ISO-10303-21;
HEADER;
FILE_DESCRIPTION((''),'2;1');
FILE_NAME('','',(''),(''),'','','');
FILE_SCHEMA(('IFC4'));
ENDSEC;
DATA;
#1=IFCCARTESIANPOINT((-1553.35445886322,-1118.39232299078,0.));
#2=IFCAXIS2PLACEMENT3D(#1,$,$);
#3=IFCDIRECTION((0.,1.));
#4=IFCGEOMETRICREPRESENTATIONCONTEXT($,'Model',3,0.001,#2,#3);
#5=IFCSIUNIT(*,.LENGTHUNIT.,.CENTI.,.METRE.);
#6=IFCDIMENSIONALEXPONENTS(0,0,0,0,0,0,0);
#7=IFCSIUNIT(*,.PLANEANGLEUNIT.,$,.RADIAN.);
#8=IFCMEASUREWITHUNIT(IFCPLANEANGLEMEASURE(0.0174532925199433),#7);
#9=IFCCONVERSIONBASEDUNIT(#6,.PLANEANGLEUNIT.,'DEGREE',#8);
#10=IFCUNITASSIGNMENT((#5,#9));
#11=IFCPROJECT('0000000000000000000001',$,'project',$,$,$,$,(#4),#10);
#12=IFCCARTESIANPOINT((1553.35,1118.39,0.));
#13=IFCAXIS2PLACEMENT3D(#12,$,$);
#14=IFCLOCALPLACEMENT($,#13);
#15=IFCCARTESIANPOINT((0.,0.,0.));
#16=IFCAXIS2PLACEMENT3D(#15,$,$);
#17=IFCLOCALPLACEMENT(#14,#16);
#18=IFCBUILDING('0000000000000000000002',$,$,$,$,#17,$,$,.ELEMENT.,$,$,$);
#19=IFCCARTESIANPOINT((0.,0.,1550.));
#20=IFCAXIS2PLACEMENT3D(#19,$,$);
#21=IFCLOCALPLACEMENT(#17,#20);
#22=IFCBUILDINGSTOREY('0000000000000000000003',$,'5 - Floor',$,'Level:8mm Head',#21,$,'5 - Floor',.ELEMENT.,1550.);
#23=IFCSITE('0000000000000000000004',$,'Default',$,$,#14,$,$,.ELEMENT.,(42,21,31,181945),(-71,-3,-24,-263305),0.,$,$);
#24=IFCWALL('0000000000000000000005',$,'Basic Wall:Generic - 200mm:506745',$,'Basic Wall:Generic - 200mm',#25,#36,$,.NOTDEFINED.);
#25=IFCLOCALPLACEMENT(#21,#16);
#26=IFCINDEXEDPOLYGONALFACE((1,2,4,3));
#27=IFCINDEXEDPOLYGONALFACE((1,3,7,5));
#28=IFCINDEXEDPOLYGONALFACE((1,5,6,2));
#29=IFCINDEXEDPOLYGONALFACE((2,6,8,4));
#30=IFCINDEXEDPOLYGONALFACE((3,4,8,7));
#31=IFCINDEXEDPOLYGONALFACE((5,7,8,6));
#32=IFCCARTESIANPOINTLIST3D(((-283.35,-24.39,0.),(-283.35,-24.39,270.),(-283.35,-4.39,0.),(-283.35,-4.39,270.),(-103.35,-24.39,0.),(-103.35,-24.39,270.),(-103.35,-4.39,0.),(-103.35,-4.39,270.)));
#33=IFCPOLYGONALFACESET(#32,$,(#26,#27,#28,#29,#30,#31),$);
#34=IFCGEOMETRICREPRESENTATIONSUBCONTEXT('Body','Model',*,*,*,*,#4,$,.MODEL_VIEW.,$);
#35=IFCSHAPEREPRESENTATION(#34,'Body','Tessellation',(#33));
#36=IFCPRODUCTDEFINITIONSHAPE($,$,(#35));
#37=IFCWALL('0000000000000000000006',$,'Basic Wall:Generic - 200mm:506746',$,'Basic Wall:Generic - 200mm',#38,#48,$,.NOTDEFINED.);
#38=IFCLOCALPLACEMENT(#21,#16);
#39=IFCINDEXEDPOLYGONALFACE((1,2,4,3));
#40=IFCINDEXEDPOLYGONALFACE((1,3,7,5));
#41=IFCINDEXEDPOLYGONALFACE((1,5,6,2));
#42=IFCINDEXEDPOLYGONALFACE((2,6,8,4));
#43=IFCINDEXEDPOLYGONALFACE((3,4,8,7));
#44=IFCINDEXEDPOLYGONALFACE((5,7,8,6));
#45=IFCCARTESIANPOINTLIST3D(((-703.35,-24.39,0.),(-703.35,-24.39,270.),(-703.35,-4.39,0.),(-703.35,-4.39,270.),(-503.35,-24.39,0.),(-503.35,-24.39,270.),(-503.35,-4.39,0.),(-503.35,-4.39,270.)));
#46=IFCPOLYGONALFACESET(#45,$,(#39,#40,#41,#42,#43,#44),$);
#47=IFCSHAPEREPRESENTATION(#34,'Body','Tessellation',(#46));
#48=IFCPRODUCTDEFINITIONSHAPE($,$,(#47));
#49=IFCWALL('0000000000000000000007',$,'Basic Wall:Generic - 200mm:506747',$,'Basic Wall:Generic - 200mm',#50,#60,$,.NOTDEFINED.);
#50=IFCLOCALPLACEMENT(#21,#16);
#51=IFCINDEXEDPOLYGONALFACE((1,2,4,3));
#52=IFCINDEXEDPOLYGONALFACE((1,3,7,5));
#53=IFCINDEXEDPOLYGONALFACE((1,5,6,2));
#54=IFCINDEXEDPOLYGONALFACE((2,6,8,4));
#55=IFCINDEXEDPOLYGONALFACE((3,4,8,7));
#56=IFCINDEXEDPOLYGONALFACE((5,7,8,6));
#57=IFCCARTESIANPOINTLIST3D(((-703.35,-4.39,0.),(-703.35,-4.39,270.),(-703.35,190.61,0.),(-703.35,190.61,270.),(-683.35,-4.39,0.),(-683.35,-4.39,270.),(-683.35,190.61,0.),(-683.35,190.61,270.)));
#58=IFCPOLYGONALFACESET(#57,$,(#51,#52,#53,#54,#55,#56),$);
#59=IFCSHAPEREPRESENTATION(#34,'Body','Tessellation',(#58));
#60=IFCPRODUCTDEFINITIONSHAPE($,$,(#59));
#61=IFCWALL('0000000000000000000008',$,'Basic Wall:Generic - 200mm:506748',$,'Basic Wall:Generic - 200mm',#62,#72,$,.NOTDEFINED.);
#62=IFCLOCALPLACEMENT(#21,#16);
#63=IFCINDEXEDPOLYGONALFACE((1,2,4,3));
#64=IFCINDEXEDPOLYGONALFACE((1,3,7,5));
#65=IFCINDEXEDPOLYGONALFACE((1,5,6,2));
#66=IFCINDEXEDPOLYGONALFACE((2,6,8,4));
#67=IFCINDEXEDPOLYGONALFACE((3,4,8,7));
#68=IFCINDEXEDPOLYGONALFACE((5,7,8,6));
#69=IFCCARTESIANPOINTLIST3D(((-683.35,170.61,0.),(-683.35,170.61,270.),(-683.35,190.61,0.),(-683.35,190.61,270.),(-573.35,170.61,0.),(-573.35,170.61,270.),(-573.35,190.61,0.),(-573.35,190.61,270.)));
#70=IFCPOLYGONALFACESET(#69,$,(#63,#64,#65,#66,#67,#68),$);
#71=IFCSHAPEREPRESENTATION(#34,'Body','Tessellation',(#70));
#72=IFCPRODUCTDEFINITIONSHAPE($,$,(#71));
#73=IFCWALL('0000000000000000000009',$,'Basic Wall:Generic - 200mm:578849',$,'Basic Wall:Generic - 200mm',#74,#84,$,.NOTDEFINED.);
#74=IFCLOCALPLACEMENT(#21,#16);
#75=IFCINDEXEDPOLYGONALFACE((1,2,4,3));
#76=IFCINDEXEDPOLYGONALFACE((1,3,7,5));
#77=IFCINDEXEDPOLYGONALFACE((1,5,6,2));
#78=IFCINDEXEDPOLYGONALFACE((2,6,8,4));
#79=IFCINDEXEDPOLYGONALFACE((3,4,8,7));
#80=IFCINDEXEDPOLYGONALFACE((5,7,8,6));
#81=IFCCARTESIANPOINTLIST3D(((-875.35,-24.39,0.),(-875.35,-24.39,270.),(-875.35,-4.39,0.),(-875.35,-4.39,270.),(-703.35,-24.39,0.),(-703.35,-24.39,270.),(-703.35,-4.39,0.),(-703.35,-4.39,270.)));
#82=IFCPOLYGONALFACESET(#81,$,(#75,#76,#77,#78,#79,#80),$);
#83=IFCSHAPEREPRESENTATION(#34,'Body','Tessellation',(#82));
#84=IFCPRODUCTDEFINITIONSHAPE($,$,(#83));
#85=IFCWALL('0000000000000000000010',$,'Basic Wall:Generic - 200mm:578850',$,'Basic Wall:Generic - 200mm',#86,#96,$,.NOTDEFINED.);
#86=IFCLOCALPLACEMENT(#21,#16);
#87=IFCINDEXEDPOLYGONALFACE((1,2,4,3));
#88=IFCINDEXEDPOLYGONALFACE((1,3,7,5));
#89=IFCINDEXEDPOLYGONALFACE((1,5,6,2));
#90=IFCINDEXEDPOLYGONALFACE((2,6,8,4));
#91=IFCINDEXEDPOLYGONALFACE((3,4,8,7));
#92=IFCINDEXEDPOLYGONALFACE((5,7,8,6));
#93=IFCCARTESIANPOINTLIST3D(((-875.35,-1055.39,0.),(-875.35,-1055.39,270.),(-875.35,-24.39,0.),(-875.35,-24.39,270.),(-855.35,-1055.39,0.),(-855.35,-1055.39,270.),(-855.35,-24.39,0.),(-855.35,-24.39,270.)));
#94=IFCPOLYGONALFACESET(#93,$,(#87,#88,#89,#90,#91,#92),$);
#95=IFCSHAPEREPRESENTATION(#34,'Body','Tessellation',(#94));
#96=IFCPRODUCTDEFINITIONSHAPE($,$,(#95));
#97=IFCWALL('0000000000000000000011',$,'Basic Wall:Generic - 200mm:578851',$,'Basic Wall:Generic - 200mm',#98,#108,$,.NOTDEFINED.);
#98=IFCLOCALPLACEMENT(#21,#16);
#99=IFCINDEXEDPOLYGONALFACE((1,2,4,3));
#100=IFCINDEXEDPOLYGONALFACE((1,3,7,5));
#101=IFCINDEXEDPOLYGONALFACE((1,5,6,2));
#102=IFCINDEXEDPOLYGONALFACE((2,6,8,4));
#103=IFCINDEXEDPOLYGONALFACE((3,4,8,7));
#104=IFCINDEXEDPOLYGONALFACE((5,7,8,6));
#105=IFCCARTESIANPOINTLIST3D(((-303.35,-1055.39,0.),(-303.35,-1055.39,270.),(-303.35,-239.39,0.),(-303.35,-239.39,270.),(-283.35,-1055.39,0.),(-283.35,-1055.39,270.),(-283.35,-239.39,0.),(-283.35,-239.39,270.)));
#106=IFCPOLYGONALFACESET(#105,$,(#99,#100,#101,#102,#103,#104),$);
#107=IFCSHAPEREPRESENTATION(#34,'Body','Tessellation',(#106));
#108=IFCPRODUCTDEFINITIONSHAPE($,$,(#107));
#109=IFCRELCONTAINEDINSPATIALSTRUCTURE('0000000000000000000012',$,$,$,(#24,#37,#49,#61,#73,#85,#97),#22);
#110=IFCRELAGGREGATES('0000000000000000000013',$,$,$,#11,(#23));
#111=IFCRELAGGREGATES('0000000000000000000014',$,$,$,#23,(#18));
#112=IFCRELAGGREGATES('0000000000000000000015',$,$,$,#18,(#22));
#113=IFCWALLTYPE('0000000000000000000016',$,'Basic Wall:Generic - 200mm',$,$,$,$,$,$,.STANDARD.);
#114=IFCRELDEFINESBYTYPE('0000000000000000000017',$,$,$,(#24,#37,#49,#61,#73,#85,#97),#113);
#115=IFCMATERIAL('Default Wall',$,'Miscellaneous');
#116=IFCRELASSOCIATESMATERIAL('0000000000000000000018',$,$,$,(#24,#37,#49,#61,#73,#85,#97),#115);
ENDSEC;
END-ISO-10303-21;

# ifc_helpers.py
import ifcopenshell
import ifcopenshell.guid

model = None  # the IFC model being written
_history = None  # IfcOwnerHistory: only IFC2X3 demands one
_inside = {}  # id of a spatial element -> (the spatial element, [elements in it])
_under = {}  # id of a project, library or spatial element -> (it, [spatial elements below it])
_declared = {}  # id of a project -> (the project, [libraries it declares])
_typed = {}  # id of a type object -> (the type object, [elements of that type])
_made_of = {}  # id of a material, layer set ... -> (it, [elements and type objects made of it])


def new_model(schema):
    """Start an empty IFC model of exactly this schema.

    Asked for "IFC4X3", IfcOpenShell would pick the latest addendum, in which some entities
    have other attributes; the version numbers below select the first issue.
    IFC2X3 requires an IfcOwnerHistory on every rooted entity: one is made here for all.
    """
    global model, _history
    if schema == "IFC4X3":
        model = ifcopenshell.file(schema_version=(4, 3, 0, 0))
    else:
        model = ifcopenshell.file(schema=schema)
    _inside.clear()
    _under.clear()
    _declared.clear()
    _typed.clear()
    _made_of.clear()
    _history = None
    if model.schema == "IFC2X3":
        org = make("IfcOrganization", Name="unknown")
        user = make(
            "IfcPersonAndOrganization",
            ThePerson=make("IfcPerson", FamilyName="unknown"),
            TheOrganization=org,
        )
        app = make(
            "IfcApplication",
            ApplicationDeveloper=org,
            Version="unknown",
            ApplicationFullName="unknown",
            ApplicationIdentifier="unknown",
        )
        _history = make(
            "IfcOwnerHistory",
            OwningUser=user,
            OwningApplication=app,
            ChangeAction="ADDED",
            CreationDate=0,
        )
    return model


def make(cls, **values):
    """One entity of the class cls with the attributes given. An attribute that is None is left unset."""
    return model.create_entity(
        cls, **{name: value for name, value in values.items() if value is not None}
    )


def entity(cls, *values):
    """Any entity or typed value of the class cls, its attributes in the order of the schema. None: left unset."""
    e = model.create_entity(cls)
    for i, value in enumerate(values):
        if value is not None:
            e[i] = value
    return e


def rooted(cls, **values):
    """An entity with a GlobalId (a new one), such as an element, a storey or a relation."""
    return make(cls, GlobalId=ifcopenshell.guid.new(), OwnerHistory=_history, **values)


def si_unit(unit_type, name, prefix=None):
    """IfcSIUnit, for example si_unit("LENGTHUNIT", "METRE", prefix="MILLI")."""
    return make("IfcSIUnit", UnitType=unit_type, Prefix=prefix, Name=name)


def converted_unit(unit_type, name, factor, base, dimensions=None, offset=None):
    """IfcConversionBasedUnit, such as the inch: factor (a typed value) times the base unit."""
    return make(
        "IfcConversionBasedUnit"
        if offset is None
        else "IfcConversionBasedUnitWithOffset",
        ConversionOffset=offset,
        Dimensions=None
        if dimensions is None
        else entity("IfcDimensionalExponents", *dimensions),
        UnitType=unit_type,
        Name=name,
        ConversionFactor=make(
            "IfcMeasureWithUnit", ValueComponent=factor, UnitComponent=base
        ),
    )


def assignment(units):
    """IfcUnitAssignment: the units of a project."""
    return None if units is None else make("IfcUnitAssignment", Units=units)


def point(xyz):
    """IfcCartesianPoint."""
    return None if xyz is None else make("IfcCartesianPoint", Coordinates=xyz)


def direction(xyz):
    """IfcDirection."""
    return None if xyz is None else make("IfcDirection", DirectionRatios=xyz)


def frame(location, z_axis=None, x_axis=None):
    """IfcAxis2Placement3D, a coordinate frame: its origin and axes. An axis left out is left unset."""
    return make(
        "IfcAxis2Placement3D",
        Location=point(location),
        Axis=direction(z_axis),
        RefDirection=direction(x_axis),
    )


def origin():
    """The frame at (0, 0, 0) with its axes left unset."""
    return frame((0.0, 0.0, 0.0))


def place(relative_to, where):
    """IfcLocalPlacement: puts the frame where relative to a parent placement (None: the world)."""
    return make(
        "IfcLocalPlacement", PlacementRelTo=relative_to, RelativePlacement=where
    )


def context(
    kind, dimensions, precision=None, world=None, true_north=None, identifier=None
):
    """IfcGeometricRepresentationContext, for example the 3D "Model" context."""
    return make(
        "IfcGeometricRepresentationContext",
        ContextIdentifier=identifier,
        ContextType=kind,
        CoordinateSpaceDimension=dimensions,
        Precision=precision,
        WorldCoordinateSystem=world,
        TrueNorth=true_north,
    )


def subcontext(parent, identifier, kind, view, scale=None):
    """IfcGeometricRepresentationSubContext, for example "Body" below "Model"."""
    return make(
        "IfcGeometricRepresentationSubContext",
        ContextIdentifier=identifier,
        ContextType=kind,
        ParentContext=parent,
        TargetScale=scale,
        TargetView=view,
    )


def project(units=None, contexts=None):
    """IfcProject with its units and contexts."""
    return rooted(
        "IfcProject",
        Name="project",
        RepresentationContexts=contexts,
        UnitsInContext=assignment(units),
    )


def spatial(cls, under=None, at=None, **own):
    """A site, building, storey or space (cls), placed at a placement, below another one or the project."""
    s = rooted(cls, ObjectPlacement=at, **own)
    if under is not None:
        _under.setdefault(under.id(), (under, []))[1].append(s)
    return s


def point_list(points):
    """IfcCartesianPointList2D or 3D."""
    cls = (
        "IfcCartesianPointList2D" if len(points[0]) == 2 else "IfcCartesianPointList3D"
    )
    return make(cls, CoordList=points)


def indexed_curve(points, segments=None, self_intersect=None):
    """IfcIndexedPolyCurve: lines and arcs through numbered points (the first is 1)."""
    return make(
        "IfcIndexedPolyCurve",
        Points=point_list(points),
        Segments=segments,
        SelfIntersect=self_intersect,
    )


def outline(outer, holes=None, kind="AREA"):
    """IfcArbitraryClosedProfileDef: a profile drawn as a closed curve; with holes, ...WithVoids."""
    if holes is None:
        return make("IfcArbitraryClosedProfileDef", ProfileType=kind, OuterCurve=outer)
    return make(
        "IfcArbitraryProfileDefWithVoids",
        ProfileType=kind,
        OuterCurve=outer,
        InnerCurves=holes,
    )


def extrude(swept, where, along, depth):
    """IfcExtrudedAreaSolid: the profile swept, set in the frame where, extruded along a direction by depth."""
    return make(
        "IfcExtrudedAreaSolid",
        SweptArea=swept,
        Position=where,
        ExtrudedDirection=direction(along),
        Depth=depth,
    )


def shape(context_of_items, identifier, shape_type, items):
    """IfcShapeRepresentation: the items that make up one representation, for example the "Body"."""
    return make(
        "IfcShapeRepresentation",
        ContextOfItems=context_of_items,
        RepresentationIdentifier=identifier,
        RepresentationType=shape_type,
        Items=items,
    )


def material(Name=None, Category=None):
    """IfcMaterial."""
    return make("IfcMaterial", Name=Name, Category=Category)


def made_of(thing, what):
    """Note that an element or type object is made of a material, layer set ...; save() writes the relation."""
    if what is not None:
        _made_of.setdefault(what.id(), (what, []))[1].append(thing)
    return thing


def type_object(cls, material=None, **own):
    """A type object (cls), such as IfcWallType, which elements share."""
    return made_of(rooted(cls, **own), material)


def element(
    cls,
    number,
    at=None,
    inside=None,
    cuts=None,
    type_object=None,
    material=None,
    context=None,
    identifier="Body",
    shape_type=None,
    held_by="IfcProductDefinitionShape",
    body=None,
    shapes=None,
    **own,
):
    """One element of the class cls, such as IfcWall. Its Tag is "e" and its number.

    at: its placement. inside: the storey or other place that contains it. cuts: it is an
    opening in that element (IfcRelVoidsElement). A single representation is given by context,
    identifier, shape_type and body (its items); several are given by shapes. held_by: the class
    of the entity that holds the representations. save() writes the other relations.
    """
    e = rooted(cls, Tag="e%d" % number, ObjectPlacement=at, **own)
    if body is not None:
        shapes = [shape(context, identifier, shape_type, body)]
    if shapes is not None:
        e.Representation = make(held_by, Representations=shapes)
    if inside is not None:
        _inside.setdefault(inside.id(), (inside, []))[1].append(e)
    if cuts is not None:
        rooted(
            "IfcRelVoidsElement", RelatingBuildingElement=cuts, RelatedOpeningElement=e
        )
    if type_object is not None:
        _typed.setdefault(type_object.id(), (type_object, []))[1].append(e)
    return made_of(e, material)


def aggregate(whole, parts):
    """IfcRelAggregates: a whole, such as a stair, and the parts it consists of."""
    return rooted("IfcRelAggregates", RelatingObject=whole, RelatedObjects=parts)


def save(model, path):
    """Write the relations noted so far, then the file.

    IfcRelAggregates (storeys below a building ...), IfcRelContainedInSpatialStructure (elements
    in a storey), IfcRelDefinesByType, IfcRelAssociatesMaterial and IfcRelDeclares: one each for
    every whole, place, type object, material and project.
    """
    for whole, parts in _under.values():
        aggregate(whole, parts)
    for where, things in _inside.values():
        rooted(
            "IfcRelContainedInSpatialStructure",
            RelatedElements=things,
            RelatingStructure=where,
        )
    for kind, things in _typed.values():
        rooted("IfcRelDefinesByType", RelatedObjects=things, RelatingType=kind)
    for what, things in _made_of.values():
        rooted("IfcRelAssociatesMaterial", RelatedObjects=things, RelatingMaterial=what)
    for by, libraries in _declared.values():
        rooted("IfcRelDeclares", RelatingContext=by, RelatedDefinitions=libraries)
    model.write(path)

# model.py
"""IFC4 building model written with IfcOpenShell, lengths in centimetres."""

from ifc_helpers import new_model, entity, si_unit, converted_unit, direction, frame, origin, place, context, subcontext, project, spatial, indexed_curve, outline, extrude, material, type_object, element, save


model = new_model("IFC4")

# Units and contexts
model_context = context("Model", 3, precision=0.001, world=frame((-1553.35445886322, -1118.39232299078, 0.0)), true_north=direction((0.0, 1.0)))
body_context = subcontext(model_context, "Body", "Model", "MODEL_VIEW")
ifc_project = project(units=[si_unit("LENGTHUNIT", "METRE", prefix="CENTI"), converted_unit("PLANEANGLEUNIT", "DEGREE", entity("IfcPlaneAngleMeasure", 0.0174532925199433), si_unit("PLANEANGLEUNIT", "RADIAN"), dimensions=[0, 0, 0, 0, 0, 0, 0])], contexts=[model_context])

# Site, building, storey
site_placement = place(None, frame((1553.35, 1118.39, 0.0)))
site = spatial("IfcSite", under=ifc_project, at=site_placement, Name="Default", CompositionType="ELEMENT", RefLatitude=(42, 21, 31, 181945), RefLongitude=(-71, -3, -24, -263305), RefElevation=0.0)
building_placement = place(site_placement, origin())
building = spatial("IfcBuilding", under=site, at=building_placement, CompositionType="ELEMENT")
storey_placement = place(building_placement, frame((0.0, 0.0, 1550.0)))
storey = spatial("IfcBuildingStorey", under=building, at=storey_placement, Name="5 - Floor", ObjectType="Level:8mm Head", LongName="5 - Floor", CompositionType="ELEMENT", Elevation=1550.0)

# Walls
ifc_material_1 = material(Name="Default Wall", Category="Miscellaneous")
wall_type_1 = type_object("IfcWallType", Name="Basic Wall:Generic - 200mm", PredefinedType="STANDARD")
wall_1_placement = place(storey_placement, frame((-283.35, -14.39, 0.0)))
element("IfcWall", 1, at=wall_1_placement, inside=storey, type_object=wall_type_1, material=ifc_material_1, Name="Basic Wall:Generic - 200mm:506745", ObjectType="Basic Wall:Generic - 200mm", PredefinedType="NOTDEFINED", context=body_context, shape_type="SweptSolid", body=[
    extrude(outline(indexed_curve([(180.0, 10.0), (0.0, 10.0), (0.0, -10.0), (180.0, -10.0), (180.0, 10.0)], self_intersect=False)), origin(), (0.0, 0.0, 1.0), 270.0),
])
wall_2_placement = place(storey_placement, frame((-503.35, -14.39, 0.0), z_axis=(0.0, 0.0, 1.0), x_axis=(-1.0, 0.0, 0.0)))
element("IfcWall", 2, at=wall_2_placement, inside=storey, type_object=wall_type_1, material=ifc_material_1, Name="Basic Wall:Generic - 200mm:506746", ObjectType="Basic Wall:Generic - 200mm", PredefinedType="NOTDEFINED", context=body_context, shape_type="SweptSolid", body=[
    extrude(outline(indexed_curve([(200.0, 10.0), (0.0, 10.0), (0.0, -10.0), (200.0, -10.0), (200.0, 10.0)], self_intersect=False)), origin(), (0.0, 0.0, 1.0), 270.0),
])
wall_3_placement = place(storey_placement, frame((-693.35, -4.39, 0.0), z_axis=(0.0, 0.0, 1.0), x_axis=(0.0, 1.0, 0.0)))
element("IfcWall", 3, at=wall_3_placement, inside=storey, type_object=wall_type_1, material=ifc_material_1, Name="Basic Wall:Generic - 200mm:506747", ObjectType="Basic Wall:Generic - 200mm", PredefinedType="NOTDEFINED", context=body_context, shape_type="SweptSolid", body=[
    extrude(outline(indexed_curve([(195.0, 10.0), (0.0, 10.0), (0.0, -10.0), (195.0, -10.0), (195.0, 10.0)], self_intersect=False)), origin(), (0.0, 0.0, 1.0), 270.0),
])
wall_4_placement = place(storey_placement, frame((-683.35, 180.61, 0.0)))
element("IfcWall", 4, at=wall_4_placement, inside=storey, type_object=wall_type_1, material=ifc_material_1, Name="Basic Wall:Generic - 200mm:506748", ObjectType="Basic Wall:Generic - 200mm", PredefinedType="NOTDEFINED", context=body_context, shape_type="SweptSolid", body=[
    extrude(outline(indexed_curve([(110.0, 10.0), (0.0, 10.0), (0.0, -10.0), (110.0, -10.0), (110.0, 10.0)], self_intersect=False)), origin(), (0.0, 0.0, 1.0), 270.0),
])
wall_5_placement = place(storey_placement, frame((-703.35, -14.39, 0.0), z_axis=(0.0, 0.0, 1.0), x_axis=(-1.0, 0.0, 0.0)))
element("IfcWall", 5, at=wall_5_placement, inside=storey, type_object=wall_type_1, material=ifc_material_1, Name="Basic Wall:Generic - 200mm:578849", ObjectType="Basic Wall:Generic - 200mm", PredefinedType="NOTDEFINED", context=body_context, shape_type="SweptSolid", body=[
    extrude(outline(indexed_curve([(172.0, 10.0), (0.0, 10.0), (0.0, -10.0), (172.0, -10.0), (172.0, 10.0)], self_intersect=False)), origin(), (0.0, 0.0, 1.0), 270.0),
])
wall_6_placement = place(storey_placement, frame((-865.35, -24.39, 0.0), z_axis=(0.0, 0.0, 1.0), x_axis=(0.0, -1.0, 0.0)))
element("IfcWall", 6, at=wall_6_placement, inside=storey, type_object=wall_type_1, material=ifc_material_1, Name="Basic Wall:Generic - 200mm:578850", ObjectType="Basic Wall:Generic - 200mm", PredefinedType="NOTDEFINED", context=body_context, shape_type="SweptSolid", body=[
    extrude(outline(indexed_curve([(1031.0, 10.0), (0.0, 10.0), (0.0, -10.0), (1031.0, -10.0), (1031.0, 10.0)], self_intersect=False)), origin(), (0.0, 0.0, 1.0), 270.0),
])
wall_7_placement = place(storey_placement, frame((-293.35, -239.39, 0.0), z_axis=(0.0, 0.0, 1.0), x_axis=(0.0, -1.0, 0.0)))
element("IfcWall", 7, at=wall_7_placement, inside=storey, type_object=wall_type_1, material=ifc_material_1, Name="Basic Wall:Generic - 200mm:578851", ObjectType="Basic Wall:Generic - 200mm", PredefinedType="NOTDEFINED", context=body_context, shape_type="SweptSolid", body=[
    extrude(outline(indexed_curve([(816.0, 10.0), (0.0, 10.0), (0.0, -10.0), (816.0, -10.0), (816.0, 10.0)], self_intersect=False)), origin(), (0.0, 0.0, 1.0), 270.0),
])

save(model, "model.ifc")
